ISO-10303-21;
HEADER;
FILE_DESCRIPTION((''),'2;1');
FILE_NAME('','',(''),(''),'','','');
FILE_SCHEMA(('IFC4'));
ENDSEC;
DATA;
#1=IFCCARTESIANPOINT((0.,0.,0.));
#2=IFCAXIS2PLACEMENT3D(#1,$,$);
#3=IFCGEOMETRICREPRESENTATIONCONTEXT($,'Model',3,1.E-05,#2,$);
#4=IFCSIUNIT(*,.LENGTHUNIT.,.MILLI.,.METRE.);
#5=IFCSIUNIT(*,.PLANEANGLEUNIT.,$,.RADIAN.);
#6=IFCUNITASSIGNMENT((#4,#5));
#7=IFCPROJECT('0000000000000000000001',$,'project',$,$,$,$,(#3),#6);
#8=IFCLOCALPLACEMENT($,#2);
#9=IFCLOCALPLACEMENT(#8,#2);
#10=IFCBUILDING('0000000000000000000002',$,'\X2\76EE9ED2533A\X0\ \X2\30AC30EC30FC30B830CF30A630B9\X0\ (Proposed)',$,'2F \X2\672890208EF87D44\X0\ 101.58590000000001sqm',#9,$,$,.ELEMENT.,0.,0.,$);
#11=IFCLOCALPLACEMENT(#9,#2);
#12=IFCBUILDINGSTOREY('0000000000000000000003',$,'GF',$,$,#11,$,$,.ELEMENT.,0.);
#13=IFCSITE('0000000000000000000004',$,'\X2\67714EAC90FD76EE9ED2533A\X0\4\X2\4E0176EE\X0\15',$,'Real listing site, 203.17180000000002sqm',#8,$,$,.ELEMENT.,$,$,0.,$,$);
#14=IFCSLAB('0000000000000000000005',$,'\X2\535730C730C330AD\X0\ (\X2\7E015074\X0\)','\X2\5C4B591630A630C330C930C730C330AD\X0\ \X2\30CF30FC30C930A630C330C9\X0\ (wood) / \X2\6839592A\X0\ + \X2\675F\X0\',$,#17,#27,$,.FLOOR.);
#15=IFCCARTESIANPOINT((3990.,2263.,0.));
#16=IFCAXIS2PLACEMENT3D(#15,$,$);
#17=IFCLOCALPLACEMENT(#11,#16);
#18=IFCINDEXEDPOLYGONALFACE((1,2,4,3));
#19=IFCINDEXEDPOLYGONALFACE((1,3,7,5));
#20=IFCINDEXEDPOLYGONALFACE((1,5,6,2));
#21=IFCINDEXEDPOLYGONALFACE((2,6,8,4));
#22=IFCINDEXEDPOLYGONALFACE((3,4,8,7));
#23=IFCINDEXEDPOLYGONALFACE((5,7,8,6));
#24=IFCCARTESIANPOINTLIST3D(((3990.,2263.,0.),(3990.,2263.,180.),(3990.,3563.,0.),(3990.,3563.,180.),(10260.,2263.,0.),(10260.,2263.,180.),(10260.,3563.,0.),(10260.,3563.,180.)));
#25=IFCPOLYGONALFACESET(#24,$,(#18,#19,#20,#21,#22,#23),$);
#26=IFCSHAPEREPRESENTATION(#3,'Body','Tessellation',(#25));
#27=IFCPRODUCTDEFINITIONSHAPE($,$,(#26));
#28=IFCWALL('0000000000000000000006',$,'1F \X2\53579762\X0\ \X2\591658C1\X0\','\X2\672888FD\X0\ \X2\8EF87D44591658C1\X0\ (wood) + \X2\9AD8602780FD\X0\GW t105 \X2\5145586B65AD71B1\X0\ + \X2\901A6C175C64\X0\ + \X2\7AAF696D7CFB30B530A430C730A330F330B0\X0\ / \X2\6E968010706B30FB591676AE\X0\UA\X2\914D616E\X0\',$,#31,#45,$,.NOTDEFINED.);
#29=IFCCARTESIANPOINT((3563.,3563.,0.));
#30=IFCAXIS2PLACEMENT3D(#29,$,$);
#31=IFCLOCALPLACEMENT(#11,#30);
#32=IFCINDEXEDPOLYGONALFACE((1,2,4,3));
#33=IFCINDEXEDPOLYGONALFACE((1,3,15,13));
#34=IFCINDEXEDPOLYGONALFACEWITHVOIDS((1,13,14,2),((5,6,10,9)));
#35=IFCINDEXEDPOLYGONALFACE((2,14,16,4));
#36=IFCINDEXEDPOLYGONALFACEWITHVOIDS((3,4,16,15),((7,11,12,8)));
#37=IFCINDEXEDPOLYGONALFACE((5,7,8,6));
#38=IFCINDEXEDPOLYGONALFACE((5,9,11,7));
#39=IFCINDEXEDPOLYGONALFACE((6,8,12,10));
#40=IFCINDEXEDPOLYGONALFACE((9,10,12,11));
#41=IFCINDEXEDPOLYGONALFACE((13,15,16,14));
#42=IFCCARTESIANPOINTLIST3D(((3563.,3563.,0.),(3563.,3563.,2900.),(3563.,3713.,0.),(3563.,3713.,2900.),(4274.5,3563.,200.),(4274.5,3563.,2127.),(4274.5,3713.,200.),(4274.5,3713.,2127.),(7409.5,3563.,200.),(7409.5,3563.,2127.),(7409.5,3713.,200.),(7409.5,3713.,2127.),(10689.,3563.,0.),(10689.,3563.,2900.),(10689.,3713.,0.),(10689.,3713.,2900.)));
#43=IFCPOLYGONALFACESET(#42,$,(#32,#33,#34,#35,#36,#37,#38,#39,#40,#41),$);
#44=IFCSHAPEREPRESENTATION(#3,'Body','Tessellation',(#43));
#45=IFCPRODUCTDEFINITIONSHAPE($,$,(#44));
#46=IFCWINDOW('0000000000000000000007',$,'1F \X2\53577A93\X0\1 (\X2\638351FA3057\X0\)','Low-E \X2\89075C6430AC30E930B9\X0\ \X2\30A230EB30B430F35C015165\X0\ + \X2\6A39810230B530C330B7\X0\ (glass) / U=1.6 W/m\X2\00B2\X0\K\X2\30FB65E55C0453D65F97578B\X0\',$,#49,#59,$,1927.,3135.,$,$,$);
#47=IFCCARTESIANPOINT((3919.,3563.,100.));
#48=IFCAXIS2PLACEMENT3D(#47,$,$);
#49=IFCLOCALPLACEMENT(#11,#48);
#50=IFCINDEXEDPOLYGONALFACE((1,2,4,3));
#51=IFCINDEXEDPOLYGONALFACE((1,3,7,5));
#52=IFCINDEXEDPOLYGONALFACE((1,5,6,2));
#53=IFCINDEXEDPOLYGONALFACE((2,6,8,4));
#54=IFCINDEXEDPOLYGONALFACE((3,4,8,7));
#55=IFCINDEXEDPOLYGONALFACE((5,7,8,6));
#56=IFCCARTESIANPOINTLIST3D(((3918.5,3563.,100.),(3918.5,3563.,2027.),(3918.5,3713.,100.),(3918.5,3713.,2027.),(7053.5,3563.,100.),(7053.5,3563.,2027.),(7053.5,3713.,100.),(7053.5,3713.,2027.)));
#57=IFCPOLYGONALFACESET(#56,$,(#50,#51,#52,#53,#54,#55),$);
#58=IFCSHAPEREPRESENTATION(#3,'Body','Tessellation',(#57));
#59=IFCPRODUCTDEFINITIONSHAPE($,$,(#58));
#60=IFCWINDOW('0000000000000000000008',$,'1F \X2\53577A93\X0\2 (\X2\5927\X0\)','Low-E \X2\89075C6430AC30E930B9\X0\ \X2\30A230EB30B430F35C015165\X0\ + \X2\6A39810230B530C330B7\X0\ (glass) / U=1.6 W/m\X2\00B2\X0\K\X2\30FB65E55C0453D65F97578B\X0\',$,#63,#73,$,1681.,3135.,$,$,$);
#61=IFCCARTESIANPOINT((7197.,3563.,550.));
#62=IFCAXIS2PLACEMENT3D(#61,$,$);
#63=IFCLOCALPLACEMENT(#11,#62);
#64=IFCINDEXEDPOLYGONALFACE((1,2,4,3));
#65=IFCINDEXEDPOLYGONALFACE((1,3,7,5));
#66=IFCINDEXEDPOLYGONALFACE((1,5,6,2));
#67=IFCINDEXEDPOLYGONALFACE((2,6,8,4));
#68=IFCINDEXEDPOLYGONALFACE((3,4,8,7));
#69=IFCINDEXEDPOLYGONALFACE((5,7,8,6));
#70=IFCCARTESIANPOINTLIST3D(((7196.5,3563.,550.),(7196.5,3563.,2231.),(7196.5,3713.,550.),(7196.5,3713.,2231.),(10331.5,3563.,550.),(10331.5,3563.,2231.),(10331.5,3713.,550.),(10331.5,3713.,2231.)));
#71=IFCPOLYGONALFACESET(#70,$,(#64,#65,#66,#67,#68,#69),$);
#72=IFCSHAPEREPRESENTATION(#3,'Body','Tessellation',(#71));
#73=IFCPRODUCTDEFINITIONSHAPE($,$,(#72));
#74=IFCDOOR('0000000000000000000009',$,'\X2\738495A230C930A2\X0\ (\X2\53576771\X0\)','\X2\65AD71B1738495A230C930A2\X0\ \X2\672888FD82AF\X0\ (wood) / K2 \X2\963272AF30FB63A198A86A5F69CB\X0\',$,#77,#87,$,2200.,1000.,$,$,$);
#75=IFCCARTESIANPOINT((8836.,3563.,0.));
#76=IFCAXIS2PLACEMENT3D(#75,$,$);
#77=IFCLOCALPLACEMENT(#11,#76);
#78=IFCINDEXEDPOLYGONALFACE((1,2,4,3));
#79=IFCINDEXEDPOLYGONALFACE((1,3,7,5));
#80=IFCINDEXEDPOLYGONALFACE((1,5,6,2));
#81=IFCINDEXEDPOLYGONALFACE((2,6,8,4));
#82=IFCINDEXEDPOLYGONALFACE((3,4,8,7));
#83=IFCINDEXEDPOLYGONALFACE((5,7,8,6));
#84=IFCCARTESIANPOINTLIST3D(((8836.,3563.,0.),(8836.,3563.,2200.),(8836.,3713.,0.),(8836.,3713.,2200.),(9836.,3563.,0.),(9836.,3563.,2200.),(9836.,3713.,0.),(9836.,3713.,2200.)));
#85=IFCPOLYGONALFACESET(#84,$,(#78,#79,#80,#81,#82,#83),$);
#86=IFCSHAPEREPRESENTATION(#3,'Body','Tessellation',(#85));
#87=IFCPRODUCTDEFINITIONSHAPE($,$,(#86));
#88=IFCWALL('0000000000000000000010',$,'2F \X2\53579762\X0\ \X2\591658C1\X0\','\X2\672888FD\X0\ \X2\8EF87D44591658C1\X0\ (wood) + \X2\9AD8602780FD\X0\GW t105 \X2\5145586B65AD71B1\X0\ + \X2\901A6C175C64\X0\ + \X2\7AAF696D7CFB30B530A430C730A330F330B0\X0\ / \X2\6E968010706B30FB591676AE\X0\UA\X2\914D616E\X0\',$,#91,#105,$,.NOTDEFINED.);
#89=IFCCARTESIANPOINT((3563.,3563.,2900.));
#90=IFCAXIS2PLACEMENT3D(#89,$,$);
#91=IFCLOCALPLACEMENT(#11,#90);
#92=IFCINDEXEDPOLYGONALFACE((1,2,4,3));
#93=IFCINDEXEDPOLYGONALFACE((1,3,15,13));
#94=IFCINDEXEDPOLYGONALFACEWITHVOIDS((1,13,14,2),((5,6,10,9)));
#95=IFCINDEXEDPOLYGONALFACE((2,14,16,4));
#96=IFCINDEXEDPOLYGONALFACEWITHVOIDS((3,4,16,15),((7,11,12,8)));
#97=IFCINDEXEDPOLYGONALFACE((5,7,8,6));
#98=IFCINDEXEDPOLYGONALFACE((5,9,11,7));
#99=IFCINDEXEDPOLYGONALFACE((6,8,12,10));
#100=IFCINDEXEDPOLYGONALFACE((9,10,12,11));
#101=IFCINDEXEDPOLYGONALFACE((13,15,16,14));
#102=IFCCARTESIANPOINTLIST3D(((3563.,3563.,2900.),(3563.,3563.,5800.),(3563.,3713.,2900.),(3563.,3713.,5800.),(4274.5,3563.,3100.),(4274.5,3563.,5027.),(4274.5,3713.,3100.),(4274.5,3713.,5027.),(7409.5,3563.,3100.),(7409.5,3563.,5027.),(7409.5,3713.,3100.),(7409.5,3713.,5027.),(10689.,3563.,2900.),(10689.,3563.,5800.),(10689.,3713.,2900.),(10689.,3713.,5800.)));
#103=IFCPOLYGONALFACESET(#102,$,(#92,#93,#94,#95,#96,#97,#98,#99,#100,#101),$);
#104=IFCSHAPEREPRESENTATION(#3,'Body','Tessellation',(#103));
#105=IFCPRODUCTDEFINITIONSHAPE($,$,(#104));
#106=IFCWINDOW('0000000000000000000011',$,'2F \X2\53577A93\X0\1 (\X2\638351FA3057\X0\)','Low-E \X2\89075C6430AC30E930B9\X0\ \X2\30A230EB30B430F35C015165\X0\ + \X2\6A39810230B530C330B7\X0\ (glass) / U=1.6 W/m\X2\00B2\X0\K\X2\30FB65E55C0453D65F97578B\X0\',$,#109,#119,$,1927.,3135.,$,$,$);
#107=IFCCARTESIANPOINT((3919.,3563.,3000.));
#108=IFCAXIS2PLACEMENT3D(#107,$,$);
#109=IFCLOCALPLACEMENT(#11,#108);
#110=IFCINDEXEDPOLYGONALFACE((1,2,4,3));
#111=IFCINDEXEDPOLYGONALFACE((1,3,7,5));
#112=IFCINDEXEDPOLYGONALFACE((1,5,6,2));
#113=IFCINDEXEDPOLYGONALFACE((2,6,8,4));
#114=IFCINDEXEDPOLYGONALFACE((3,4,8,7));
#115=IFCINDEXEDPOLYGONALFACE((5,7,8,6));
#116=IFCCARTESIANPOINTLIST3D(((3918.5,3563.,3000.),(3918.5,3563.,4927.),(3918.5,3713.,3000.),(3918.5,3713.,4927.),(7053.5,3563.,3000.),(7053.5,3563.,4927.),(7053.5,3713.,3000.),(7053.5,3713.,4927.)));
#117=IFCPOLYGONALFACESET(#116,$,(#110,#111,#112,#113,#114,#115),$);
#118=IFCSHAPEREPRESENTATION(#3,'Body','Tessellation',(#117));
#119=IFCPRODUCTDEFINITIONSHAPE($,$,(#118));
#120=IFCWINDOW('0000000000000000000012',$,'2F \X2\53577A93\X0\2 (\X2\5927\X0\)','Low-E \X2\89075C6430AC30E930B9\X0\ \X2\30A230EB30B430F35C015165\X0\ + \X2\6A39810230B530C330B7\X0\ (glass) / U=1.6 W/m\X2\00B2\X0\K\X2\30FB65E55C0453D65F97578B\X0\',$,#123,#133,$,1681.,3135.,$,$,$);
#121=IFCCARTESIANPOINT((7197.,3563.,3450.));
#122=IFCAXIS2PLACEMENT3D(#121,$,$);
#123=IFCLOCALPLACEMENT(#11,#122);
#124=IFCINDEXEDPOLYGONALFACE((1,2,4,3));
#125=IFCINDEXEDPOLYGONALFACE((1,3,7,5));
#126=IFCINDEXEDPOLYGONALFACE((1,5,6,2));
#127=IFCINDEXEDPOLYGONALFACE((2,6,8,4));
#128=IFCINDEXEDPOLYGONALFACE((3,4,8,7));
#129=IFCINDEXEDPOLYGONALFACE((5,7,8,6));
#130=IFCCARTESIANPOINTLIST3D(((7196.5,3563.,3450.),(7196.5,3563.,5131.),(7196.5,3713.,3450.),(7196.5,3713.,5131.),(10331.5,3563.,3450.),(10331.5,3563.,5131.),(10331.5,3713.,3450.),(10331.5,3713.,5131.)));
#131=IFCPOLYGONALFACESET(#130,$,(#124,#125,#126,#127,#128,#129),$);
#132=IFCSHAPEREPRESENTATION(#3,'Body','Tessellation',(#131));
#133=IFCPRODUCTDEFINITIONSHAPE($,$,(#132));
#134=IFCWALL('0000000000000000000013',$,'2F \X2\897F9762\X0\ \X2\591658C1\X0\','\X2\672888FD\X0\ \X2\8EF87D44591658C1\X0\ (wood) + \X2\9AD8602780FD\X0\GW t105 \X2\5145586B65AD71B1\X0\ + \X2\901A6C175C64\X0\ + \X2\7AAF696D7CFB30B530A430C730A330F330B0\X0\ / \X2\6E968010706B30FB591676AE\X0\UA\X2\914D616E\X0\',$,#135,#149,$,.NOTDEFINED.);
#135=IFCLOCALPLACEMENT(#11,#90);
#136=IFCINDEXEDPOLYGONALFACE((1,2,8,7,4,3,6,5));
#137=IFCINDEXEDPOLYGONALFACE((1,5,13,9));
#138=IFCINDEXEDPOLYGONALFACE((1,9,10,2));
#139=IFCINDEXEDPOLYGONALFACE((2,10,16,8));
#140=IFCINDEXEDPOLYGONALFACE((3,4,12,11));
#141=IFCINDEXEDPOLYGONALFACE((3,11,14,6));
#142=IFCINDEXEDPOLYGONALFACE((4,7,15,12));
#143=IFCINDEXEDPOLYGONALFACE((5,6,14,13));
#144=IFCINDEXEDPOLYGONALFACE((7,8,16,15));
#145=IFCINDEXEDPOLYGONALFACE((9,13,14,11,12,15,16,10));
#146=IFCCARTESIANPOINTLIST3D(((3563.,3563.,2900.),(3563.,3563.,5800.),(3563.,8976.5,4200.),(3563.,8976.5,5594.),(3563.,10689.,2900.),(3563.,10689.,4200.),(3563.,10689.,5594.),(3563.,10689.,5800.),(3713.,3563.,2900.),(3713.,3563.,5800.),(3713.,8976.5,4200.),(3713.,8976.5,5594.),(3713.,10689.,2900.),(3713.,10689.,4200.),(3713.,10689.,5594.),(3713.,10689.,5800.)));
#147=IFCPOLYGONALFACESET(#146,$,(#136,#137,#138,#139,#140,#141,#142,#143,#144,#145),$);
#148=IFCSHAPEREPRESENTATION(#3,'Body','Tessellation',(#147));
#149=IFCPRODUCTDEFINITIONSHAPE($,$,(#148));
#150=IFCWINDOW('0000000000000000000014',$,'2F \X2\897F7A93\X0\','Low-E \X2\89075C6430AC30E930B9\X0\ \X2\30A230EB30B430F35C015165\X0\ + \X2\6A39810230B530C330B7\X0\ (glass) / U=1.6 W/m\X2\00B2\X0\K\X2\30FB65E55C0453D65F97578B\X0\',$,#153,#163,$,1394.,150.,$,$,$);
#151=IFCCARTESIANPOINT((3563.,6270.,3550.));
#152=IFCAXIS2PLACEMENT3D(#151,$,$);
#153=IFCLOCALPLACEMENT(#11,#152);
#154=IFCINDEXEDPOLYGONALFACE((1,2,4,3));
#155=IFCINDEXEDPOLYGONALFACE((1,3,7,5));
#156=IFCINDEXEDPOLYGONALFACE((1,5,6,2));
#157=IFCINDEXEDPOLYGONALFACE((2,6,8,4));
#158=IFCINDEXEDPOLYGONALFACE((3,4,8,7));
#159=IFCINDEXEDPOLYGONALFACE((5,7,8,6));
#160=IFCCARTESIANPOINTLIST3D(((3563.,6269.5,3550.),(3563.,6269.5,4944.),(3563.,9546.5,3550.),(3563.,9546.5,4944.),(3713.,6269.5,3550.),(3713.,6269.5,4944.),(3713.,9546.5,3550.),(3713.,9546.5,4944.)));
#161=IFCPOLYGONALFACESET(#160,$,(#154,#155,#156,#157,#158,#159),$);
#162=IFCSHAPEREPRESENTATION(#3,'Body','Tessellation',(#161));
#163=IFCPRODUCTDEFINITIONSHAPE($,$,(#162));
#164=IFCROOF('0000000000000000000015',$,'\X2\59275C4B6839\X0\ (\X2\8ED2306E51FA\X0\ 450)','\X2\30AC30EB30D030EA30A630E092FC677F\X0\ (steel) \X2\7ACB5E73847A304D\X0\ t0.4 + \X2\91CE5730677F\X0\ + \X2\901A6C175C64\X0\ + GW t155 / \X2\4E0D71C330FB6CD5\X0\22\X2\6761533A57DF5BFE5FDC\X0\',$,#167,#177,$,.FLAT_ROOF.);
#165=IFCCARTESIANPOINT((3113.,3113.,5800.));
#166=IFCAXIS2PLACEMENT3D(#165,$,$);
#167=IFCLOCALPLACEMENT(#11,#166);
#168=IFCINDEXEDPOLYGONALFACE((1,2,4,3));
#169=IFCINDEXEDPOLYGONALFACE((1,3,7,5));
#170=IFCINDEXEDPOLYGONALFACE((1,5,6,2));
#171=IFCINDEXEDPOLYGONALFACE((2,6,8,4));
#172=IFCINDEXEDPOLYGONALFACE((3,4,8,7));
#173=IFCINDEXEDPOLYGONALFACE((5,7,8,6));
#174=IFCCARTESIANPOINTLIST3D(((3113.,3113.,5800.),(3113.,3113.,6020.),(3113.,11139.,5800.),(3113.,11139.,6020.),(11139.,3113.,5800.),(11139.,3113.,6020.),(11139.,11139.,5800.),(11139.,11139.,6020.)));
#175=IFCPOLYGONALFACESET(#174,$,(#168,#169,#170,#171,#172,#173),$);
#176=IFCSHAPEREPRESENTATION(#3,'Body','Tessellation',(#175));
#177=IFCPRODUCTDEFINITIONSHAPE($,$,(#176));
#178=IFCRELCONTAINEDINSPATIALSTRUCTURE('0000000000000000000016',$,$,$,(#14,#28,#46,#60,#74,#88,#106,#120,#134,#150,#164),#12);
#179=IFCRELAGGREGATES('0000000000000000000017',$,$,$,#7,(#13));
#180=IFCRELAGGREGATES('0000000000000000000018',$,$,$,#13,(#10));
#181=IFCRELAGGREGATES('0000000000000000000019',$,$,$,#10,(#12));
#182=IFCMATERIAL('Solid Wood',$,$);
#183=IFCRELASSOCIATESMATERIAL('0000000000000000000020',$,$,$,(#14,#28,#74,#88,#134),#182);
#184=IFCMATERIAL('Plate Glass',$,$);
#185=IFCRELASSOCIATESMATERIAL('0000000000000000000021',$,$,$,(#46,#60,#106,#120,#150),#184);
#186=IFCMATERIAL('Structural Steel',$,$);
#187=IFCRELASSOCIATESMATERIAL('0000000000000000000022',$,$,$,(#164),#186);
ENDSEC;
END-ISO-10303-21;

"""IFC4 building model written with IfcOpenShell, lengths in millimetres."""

from ifc_helpers import new_model, si_unit, frame, frame_2d, origin, place, context, project, spatial, rectangle, extrude, material, element, fill, save


model = new_model("IFC4")

# Units and contexts
model_context = context("Model", 3, precision=1e-05, world=origin())
ifc_project = project(units=[si_unit("LENGTHUNIT", "METRE", prefix="MILLI"), si_unit("PLANEANGLEUNIT", "RADIAN")], contexts=[model_context])

# Site, building, storey
site_placement = place(None, origin())
site = spatial("IfcSite", under=ifc_project, at=site_placement, Name="東京都目黒区4丁目15", ObjectType="Real listing site, 203.17180000000002sqm", CompositionType="ELEMENT", RefElevation=0.0)
building_placement = place(site_placement, origin())
building = spatial("IfcBuilding", under=site, at=building_placement, Name="目黒区 ガレージハウス (Proposed)", ObjectType="2F 木造軸組 101.58590000000001sqm", CompositionType="ELEMENT", ElevationOfRefHeight=0.0, ElevationOfTerrain=0.0)
storey_placement = place(building_placement, origin())
storey = spatial("IfcBuildingStorey", under=building, at=storey_placement, Name="GF", CompositionType="ELEMENT", Elevation=0.0)

# Slab
ifc_material_1 = material(Name="Solid Wood")
slab_1_placement = place(storey_placement, frame((3990.0, 2263.0, 0.0)))
element("IfcSlab", 1, at=slab_1_placement, inside=storey, material=ifc_material_1, Name="南デッキ (縁側)", Description="屋外ウッドデッキ ハードウッド (wood) / 根太 + 束", PredefinedType="FLOOR", context=model_context, shape_type="SweptSolid", body=[
    extrude(rectangle(XDim=6270.0, YDim=1300.0, at=frame_2d((3135.0, 650.0))), frame((3990.0, 2263.0, 0.0)), (0.0, 0.0, 1.0), 180.0),
])

# Wall, openings, windows, door
wall_1_placement = place(storey_placement, frame((3563.0, 3563.0, 0.0)))
wall_1 = element("IfcWall", 2, at=wall_1_placement, inside=storey, material=ifc_material_1, Name="1F 南面 外壁", Description="木製 軸組外壁 (wood) + 高性能GW t105 充填断熱 + 通気層 + 窯業系サイディング / 準耐火・外皮UA配慮", PredefinedType="NOTDEFINED", context=model_context, shape_type="SweptSolid", body=[
    extrude(rectangle(XDim=7126.0, YDim=150.0, at=frame_2d((3563.0, 75.0))), frame((3563.0, 3563.0, 0.0)), (0.0, 0.0, 1.0), 2900.0),
])
opening_1_placement = place(storey_placement, frame((3919.0, 3563.0, 100.0)))
opening_1 = element("IfcOpeningElement", 3, at=opening_1_placement, cuts=wall_1, PredefinedType="NOTDEFINED", context=model_context, shape_type="SweptSolid", body=[
    extrude(rectangle(XDim=3135.0, YDim=150.0, at=frame_2d((1567.0, 75.0))), frame((3919.0, 3563.0, 100.0)), (0.0, 0.0, 1.0), 1927.0),
])
opening_2_placement = place(storey_placement, frame((7197.0, 3563.0, 550.0)))
opening_2 = element("IfcOpeningElement", 4, at=opening_2_placement, cuts=wall_1, PredefinedType="NOTDEFINED", context=model_context, shape_type="SweptSolid", body=[
    extrude(rectangle(XDim=3135.0, YDim=150.0, at=frame_2d((1567.0, 75.0))), frame((7197.0, 3563.0, 550.0)), (0.0, 0.0, 1.0), 1681.0),
])
opening_3_placement = place(storey_placement, frame((8836.0, 3563.0, 0.0)))
opening_3 = element("IfcOpeningElement", 5, at=opening_3_placement, cuts=wall_1, PredefinedType="NOTDEFINED", context=model_context, shape_type="SweptSolid", body=[
    extrude(rectangle(XDim=1000.0, YDim=150.0, at=frame_2d((500.0, 75.0))), frame((8836.0, 3563.0, 0.0)), (0.0, 0.0, 1.0), 2200.0),
])
ifc_material_2 = material(Name="Plate Glass")
window_1_placement = place(storey_placement, frame((3919.0, 3563.0, 100.0)))
window_1 = element("IfcWindow", 6, at=window_1_placement, inside=storey, material=ifc_material_2, Name="1F 南窓1 (掃出し)", Description="Low-E 複層ガラス アルゴン封入 + 樹脂サッシ (glass) / U=1.6 W/m²K・日射取得型", OverallHeight=1927.0, OverallWidth=3135.0, context=model_context, shape_type="SweptSolid", body=[
    extrude(rectangle(XDim=3135.0, YDim=150.0, at=frame_2d((1567.0, 75.0))), frame((3919.0, 3563.0, 100.0)), (0.0, 0.0, 1.0), 1927.0),
])
fill(opening_1, window_1)
window_2_placement = place(storey_placement, frame((7197.0, 3563.0, 550.0)))
window_2 = element("IfcWindow", 7, at=window_2_placement, inside=storey, material=ifc_material_2, Name="1F 南窓2 (大)", Description="Low-E 複層ガラス アルゴン封入 + 樹脂サッシ (glass) / U=1.6 W/m²K・日射取得型", OverallHeight=1681.0, OverallWidth=3135.0, context=model_context, shape_type="SweptSolid", body=[
    extrude(rectangle(XDim=3135.0, YDim=150.0, at=frame_2d((1567.0, 75.0))), frame((7197.0, 3563.0, 550.0)), (0.0, 0.0, 1.0), 1681.0),
])
fill(opening_2, window_2)
door_placement = place(storey_placement, frame((8836.0, 3563.0, 0.0)))
door = element("IfcDoor", 8, at=door_placement, inside=storey, material=ifc_material_1, Name="玄関ドア (南東)", Description="断熱玄関ドア 木製芯 (wood) / K2 防犯・採風機構", OverallHeight=2200.0, OverallWidth=1000.0, context=model_context, shape_type="SweptSolid", body=[
    extrude(rectangle(XDim=1000.0, YDim=150.0, at=frame_2d((500.0, 75.0))), frame((8836.0, 3563.0, 0.0)), (0.0, 0.0, 1.0), 2200.0),
])
fill(opening_3, door)

# Wall, openings, windows
wall_2_placement = place(storey_placement, frame((3563.0, 3563.0, 2900.0)))
wall_2 = element("IfcWall", 9, at=wall_2_placement, inside=storey, material=ifc_material_1, Name="2F 南面 外壁", Description="木製 軸組外壁 (wood) + 高性能GW t105 充填断熱 + 通気層 + 窯業系サイディング / 準耐火・外皮UA配慮", PredefinedType="NOTDEFINED", context=model_context, shape_type="SweptSolid", body=[
    extrude(rectangle(XDim=7126.0, YDim=150.0, at=frame_2d((3563.0, 75.0))), frame((3563.0, 3563.0, 2900.0)), (0.0, 0.0, 1.0), 2900.0),
])
opening_4_placement = place(storey_placement, frame((3919.0, 3563.0, 3000.0)))
opening_4 = element("IfcOpeningElement", 10, at=opening_4_placement, cuts=wall_2, PredefinedType="NOTDEFINED", context=model_context, shape_type="SweptSolid", body=[
    extrude(rectangle(XDim=3135.0, YDim=150.0, at=frame_2d((1567.0, 75.0))), frame((3919.0, 3563.0, 3000.0)), (0.0, 0.0, 1.0), 1927.0),
])
opening_5_placement = place(storey_placement, frame((7197.0, 3563.0, 3450.0)))
opening_5 = element("IfcOpeningElement", 11, at=opening_5_placement, cuts=wall_2, PredefinedType="NOTDEFINED", context=model_context, shape_type="SweptSolid", body=[
    extrude(rectangle(XDim=3135.0, YDim=150.0, at=frame_2d((1567.0, 75.0))), frame((7197.0, 3563.0, 3450.0)), (0.0, 0.0, 1.0), 1681.0),
])
window_3_placement = place(storey_placement, frame((3919.0, 3563.0, 3000.0)))
window_3 = element("IfcWindow", 12, at=window_3_placement, inside=storey, material=ifc_material_2, Name="2F 南窓1 (掃出し)", Description="Low-E 複層ガラス アルゴン封入 + 樹脂サッシ (glass) / U=1.6 W/m²K・日射取得型", OverallHeight=1927.0, OverallWidth=3135.0, context=model_context, shape_type="SweptSolid", body=[
    extrude(rectangle(XDim=3135.0, YDim=150.0, at=frame_2d((1567.0, 75.0))), frame((3919.0, 3563.0, 3000.0)), (0.0, 0.0, 1.0), 1927.0),
])
fill(opening_4, window_3)
window_4_placement = place(storey_placement, frame((7197.0, 3563.0, 3450.0)))
window_4 = element("IfcWindow", 13, at=window_4_placement, inside=storey, material=ifc_material_2, Name="2F 南窓2 (大)", Description="Low-E 複層ガラス アルゴン封入 + 樹脂サッシ (glass) / U=1.6 W/m²K・日射取得型", OverallHeight=1681.0, OverallWidth=3135.0, context=model_context, shape_type="SweptSolid", body=[
    extrude(rectangle(XDim=3135.0, YDim=150.0, at=frame_2d((1567.0, 75.0))), frame((7197.0, 3563.0, 3450.0)), (0.0, 0.0, 1.0), 1681.0),
])
fill(opening_5, window_4)

# Wall, opening, window
wall_3_placement = place(storey_placement, frame((3563.0, 3563.0, 2900.0)))
wall_3 = element("IfcWall", 14, at=wall_3_placement, inside=storey, material=ifc_material_1, Name="2F 西面 外壁", Description="木製 軸組外壁 (wood) + 高性能GW t105 充填断熱 + 通気層 + 窯業系サイディング / 準耐火・外皮UA配慮", PredefinedType="NOTDEFINED", context=model_context, shape_type="SweptSolid", body=[
    extrude(rectangle(XDim=150.0, YDim=7126.0, at=frame_2d((75.0, 3563.0))), frame((3563.0, 3563.0, 2900.0)), (0.0, 0.0, 1.0), 2900.0),
])
opening_6_placement = place(storey_placement, frame((3563.0, 6270.0, 3550.0)))
opening_6 = element("IfcOpeningElement", 15, at=opening_6_placement, cuts=wall_3, PredefinedType="NOTDEFINED", context=model_context, shape_type="SweptSolid", body=[
    extrude(rectangle(XDim=150.0, YDim=3277.0, at=frame_2d((75.0, 1638.0))), frame((3563.0, 6270.0, 3550.0)), (0.0, 0.0, 1.0), 1394.0),
])
window_5_placement = place(storey_placement, frame((3563.0, 6270.0, 3550.0)))
window_5 = element("IfcWindow", 16, at=window_5_placement, inside=storey, material=ifc_material_2, Name="2F 西窓", Description="Low-E 複層ガラス アルゴン封入 + 樹脂サッシ (glass) / U=1.6 W/m²K・日射取得型", OverallHeight=1394.0, OverallWidth=150.0, context=model_context, shape_type="SweptSolid", body=[
    extrude(rectangle(XDim=150.0, YDim=3277.0, at=frame_2d((75.0, 1638.0))), frame((3563.0, 6270.0, 3550.0)), (0.0, 0.0, 1.0), 1394.0),
])
fill(opening_6, window_5)

# Roof
ifc_material_3 = material(Name="Structural Steel")
roof_placement = place(storey_placement, frame((3113.0, 3113.0, 5800.0)))
element("IfcRoof", 17, at=roof_placement, inside=storey, material=ifc_material_3, Name="大屋根 (軒の出 450)", Description="ガルバリウム鋼板 (steel) 立平葺き t0.4 + 野地板 + 通気層 + GW t155 / 不燃・法22条区域対応", PredefinedType="FLAT_ROOF", context=model_context, shape_type="SweptSolid", body=[
    extrude(rectangle(XDim=8026.0, YDim=8026.0, at=frame_2d((4013.0, 4013.0))), frame((3113.0, 3113.0, 5800.0)), (0.0, 0.0, 1.0), 220.0),
])

save(model, "model.ifc")
